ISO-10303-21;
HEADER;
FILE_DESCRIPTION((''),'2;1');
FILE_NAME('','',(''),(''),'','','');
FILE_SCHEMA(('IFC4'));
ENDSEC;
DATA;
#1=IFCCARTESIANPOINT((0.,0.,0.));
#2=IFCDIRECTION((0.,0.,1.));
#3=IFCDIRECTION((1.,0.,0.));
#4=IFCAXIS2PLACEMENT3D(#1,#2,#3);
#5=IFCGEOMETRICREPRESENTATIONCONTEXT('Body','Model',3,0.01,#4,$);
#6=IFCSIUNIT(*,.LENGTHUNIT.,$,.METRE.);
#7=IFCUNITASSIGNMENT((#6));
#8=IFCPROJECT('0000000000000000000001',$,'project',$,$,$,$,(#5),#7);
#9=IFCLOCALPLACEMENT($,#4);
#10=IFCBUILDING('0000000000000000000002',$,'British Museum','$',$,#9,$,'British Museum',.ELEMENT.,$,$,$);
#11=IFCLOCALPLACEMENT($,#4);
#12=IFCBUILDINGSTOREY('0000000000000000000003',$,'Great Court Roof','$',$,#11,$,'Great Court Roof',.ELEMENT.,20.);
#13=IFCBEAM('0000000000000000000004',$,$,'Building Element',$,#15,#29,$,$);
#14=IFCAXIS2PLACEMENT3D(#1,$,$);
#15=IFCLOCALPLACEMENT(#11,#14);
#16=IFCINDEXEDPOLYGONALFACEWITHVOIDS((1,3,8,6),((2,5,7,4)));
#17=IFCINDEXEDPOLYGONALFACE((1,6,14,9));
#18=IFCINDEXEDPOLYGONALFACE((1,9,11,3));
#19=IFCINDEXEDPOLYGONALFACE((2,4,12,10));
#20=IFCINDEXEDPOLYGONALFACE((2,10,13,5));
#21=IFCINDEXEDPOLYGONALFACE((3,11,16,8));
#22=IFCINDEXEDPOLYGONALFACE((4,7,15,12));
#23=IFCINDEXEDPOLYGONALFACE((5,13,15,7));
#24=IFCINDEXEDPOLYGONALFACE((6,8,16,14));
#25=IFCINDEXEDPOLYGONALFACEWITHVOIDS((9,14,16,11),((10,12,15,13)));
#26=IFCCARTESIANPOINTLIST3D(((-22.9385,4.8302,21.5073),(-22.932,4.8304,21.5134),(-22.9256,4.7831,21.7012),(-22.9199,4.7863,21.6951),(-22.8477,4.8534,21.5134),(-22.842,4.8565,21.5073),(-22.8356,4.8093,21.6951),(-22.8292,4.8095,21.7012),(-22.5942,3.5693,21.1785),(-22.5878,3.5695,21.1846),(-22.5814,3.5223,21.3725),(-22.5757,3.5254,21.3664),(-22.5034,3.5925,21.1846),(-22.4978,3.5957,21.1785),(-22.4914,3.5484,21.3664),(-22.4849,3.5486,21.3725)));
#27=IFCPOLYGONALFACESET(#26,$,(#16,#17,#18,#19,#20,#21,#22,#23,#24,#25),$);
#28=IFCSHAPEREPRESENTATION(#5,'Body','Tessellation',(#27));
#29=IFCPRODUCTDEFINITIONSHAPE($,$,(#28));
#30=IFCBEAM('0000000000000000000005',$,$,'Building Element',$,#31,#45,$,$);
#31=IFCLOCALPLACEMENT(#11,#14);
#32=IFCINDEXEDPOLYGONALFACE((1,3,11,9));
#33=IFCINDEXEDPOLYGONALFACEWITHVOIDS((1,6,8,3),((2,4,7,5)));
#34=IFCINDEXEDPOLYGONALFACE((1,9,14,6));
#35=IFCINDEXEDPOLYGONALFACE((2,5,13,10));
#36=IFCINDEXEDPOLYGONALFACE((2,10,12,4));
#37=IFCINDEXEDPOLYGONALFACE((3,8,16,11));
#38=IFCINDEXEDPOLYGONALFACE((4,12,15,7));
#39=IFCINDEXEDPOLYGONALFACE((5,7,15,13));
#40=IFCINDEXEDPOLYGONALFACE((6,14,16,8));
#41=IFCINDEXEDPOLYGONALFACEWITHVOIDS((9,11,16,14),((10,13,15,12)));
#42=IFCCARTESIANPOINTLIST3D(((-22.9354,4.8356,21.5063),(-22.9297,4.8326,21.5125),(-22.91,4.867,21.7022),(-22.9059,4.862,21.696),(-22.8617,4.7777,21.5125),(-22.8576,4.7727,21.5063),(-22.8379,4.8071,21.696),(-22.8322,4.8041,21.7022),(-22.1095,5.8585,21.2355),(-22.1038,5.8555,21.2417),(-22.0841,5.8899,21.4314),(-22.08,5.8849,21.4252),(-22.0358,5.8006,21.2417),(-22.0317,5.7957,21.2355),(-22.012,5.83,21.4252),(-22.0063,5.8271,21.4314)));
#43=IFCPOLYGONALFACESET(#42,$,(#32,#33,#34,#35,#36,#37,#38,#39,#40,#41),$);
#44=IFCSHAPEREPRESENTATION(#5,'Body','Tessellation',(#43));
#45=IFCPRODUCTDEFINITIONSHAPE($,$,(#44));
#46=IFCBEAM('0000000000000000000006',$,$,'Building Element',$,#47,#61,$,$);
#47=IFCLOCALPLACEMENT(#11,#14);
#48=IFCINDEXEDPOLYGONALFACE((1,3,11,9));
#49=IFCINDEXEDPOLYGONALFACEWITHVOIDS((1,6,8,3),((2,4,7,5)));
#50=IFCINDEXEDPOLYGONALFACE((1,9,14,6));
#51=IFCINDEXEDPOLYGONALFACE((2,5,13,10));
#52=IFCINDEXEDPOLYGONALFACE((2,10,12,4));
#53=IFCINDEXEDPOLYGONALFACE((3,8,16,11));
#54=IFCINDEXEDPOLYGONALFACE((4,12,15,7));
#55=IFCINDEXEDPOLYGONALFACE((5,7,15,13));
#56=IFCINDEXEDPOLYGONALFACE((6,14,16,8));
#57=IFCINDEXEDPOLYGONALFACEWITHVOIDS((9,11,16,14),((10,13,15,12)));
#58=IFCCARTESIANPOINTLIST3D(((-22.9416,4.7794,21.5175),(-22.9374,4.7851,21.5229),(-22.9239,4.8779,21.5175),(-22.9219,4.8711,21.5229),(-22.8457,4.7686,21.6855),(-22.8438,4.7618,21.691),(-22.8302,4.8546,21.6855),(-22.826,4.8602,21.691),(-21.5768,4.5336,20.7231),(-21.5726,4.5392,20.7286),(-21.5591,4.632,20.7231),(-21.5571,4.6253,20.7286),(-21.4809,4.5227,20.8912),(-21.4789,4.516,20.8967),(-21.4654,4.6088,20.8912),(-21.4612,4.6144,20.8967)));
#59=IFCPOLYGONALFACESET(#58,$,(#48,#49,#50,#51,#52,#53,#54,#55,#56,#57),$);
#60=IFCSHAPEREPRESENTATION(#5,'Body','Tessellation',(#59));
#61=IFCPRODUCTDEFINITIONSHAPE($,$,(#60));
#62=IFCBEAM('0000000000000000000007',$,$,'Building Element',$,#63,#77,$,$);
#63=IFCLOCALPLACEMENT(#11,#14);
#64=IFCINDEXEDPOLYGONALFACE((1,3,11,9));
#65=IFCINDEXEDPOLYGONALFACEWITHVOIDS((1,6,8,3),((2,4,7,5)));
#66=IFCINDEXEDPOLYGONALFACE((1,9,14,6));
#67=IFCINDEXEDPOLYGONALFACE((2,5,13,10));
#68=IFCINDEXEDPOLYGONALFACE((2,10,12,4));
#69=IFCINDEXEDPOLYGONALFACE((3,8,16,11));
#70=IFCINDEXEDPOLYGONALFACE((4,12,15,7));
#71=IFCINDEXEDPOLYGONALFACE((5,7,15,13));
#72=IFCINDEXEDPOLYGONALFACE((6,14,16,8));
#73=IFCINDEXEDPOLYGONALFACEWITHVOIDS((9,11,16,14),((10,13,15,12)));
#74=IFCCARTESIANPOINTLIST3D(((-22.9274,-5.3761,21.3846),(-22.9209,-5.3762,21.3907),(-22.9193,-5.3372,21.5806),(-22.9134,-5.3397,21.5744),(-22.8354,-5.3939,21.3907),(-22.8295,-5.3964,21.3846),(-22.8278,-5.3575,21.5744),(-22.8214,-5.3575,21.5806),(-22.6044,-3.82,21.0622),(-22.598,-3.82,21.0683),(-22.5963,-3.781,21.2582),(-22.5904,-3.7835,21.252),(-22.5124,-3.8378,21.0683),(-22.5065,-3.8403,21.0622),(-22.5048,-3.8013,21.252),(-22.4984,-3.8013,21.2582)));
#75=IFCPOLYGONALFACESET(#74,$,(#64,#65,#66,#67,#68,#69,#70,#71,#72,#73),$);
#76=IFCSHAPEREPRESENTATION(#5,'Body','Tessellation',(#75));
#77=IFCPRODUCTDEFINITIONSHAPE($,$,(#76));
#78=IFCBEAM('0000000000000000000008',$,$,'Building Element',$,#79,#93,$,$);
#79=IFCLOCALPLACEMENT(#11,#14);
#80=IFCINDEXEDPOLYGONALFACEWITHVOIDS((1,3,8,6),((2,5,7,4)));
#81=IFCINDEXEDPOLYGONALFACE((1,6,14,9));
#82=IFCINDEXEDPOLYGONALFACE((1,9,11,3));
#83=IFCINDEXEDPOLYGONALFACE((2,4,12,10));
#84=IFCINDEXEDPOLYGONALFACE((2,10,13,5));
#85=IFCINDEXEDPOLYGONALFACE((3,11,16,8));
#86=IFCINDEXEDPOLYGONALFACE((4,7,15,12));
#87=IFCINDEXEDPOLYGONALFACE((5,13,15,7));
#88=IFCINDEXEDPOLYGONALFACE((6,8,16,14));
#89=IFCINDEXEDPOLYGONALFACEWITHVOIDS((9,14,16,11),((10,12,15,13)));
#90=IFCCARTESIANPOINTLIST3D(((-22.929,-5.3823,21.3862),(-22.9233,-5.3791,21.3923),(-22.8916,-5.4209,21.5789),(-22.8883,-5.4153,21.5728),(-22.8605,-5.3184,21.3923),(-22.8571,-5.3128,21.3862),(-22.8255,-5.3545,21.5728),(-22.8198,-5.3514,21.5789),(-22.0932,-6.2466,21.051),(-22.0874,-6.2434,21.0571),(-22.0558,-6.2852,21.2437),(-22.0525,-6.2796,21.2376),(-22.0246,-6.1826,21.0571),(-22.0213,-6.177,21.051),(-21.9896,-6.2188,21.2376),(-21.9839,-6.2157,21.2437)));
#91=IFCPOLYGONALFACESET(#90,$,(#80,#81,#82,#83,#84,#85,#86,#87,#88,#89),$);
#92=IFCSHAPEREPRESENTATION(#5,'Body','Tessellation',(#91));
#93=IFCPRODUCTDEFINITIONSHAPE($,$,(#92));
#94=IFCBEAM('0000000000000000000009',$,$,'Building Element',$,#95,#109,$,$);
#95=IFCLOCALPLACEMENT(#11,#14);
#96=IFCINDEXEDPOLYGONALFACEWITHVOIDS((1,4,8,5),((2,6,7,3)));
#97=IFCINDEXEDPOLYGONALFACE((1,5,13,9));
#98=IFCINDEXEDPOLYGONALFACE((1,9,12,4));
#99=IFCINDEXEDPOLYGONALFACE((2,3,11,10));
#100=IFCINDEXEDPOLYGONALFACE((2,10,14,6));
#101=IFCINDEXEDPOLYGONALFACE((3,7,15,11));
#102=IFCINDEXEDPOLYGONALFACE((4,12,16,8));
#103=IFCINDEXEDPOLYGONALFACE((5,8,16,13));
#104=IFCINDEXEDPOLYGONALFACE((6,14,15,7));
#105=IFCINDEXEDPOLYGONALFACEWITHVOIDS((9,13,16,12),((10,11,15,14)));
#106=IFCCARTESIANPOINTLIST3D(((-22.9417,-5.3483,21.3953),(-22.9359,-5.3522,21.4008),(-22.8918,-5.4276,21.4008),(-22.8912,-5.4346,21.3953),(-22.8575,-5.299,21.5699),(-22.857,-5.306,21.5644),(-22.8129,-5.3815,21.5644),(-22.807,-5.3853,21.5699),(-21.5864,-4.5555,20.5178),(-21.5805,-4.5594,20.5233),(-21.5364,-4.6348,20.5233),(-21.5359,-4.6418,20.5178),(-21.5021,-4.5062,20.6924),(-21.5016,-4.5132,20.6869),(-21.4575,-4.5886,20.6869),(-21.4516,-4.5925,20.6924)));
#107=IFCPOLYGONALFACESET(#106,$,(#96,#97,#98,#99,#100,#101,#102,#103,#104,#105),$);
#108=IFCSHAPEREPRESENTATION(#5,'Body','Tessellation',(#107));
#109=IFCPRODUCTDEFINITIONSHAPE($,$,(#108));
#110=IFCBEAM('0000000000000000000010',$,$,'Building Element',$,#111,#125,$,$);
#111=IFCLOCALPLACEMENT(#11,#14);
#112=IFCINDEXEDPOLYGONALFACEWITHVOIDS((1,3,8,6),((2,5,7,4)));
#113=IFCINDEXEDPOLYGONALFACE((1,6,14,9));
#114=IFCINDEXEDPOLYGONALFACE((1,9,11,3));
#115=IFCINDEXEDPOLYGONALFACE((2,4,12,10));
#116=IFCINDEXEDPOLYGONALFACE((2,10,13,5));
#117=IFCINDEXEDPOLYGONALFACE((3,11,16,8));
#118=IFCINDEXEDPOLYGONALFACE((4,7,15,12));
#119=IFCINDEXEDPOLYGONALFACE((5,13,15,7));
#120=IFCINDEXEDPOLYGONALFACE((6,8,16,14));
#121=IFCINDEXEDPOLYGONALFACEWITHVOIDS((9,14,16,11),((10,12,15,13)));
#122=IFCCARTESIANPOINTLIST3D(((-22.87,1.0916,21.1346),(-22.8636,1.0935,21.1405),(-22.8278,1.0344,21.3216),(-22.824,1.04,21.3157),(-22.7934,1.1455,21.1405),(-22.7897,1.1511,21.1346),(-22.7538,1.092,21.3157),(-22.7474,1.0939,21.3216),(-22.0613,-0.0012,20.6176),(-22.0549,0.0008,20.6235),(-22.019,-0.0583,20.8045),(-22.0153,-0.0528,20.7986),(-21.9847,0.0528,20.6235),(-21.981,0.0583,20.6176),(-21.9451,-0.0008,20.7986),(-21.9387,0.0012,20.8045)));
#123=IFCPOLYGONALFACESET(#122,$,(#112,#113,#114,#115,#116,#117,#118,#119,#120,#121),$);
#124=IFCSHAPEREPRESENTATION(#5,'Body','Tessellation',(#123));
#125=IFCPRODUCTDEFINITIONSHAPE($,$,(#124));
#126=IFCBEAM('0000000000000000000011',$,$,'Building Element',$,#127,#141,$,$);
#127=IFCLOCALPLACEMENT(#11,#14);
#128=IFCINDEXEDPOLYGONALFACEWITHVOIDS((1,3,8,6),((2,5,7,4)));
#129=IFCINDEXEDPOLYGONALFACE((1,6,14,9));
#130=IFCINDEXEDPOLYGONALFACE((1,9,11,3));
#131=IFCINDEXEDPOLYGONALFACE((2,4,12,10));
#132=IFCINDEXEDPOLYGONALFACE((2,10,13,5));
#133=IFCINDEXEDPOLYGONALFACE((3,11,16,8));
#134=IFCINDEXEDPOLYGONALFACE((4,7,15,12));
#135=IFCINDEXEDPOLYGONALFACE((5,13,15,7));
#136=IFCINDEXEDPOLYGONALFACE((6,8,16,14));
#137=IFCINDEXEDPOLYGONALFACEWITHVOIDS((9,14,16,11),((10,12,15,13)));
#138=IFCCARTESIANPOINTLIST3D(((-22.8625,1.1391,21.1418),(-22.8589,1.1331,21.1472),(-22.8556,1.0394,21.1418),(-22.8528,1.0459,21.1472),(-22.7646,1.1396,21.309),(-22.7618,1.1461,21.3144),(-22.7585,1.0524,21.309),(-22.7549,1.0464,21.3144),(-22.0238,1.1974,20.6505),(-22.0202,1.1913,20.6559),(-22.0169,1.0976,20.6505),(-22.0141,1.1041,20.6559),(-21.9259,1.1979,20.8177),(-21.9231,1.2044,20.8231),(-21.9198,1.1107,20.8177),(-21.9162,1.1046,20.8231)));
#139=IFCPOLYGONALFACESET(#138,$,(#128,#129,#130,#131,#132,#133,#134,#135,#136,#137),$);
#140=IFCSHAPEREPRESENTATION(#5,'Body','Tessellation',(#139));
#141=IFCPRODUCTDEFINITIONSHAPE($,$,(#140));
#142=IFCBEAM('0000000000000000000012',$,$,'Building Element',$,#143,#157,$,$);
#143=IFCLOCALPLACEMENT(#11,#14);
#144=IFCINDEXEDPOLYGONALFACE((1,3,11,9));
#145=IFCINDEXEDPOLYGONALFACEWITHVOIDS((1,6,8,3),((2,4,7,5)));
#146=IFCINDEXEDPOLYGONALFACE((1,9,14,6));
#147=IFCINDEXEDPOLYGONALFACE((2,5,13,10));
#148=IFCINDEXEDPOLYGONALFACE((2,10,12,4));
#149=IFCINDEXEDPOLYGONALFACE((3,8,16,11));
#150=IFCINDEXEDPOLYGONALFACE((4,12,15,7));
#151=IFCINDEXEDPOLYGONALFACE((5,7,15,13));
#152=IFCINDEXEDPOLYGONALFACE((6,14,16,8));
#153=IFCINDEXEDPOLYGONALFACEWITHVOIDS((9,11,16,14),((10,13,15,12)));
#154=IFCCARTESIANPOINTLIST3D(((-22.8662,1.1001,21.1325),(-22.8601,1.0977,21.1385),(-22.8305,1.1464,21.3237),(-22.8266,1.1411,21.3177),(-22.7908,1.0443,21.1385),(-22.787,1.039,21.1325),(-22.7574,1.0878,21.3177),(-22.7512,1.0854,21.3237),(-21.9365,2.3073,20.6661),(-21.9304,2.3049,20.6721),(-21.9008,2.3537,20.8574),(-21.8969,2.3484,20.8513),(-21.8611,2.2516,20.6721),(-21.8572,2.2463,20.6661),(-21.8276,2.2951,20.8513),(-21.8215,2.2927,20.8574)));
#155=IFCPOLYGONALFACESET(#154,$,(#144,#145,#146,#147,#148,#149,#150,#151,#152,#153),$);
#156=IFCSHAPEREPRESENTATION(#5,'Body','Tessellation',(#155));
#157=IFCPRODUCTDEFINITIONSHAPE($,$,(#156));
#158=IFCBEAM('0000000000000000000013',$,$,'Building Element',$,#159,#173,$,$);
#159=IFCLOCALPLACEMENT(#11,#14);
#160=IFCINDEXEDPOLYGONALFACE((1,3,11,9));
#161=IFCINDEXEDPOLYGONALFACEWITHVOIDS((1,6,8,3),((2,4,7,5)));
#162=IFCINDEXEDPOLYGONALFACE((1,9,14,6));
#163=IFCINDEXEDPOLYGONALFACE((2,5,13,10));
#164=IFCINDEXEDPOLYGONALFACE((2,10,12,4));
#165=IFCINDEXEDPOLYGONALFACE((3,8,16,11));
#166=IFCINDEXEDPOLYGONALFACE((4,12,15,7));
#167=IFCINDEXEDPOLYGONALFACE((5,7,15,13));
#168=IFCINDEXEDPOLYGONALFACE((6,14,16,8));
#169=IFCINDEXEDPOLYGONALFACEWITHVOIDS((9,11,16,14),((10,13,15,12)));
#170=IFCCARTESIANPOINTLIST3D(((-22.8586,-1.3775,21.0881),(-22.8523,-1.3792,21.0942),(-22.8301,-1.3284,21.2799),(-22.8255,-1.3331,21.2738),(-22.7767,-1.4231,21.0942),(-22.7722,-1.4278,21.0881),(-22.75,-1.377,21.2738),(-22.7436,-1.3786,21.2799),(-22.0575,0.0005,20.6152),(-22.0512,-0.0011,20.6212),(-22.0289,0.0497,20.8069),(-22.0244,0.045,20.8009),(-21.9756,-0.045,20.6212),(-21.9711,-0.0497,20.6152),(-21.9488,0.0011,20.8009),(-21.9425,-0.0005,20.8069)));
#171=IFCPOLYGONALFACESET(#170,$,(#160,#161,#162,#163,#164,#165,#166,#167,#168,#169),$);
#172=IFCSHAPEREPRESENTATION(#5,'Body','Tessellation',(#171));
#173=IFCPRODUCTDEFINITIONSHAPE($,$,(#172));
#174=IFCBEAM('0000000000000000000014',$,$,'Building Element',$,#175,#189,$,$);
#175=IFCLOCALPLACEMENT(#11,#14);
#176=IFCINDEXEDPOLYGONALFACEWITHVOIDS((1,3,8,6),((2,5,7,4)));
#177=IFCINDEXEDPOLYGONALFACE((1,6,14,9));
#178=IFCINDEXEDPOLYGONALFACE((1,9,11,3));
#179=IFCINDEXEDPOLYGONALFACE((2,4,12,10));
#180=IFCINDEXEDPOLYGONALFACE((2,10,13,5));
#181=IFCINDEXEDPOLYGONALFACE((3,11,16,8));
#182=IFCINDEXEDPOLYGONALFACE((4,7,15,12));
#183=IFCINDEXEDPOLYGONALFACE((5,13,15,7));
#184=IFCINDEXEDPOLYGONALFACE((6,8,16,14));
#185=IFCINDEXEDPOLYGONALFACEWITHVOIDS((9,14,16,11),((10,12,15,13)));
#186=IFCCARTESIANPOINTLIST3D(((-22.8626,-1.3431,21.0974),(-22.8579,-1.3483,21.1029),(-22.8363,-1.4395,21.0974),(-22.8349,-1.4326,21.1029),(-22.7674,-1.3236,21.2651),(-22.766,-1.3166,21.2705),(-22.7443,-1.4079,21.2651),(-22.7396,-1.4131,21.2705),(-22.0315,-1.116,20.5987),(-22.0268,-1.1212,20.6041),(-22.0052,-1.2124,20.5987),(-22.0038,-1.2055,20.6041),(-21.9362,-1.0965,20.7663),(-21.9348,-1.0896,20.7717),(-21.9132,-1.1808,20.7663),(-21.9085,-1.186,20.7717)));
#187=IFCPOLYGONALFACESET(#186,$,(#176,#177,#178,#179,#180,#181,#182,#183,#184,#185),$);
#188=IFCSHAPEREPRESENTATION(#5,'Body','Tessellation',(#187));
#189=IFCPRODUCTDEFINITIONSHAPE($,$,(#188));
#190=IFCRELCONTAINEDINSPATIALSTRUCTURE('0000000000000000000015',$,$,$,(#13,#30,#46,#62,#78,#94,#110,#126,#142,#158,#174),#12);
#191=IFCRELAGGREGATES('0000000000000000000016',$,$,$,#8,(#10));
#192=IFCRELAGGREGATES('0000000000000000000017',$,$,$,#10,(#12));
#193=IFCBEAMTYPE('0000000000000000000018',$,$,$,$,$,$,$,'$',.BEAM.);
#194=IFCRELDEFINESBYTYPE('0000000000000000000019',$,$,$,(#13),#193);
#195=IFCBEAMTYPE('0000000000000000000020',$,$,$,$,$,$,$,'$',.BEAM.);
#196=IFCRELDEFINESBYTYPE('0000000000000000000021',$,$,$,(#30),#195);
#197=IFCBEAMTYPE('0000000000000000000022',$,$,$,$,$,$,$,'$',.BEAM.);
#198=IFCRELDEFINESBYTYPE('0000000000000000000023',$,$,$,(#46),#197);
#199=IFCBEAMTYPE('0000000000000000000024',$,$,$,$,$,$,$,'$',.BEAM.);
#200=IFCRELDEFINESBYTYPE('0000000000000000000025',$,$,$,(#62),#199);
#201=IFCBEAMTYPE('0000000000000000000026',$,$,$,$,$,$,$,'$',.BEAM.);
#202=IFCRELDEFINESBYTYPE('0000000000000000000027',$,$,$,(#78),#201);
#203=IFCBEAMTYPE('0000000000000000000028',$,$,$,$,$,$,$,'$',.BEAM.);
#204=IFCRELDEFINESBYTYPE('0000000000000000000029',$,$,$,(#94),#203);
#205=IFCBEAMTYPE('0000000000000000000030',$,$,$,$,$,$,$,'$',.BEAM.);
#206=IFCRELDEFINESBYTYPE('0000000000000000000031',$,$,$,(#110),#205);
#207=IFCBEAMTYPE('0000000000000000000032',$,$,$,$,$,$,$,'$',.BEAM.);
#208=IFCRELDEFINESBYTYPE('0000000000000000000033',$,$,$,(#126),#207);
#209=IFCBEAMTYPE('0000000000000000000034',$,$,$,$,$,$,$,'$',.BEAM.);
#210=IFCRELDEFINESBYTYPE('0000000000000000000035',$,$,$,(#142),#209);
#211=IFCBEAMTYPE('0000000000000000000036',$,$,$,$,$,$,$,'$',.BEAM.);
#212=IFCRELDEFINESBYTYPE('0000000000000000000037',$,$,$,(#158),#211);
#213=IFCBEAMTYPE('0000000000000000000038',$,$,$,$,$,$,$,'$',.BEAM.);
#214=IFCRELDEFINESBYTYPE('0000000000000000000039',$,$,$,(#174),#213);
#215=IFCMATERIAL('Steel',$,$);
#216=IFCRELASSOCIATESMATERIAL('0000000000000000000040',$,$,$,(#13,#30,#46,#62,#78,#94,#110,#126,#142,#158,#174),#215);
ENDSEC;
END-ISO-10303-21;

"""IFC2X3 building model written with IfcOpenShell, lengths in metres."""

from ifc_helpers import new_model, si_unit, frame, origin_with_axes, origin_2d, place, context, project, spatial, hollow_rectangle, extrude, material, type_object, element, save


model = new_model("IFC2X3")

# Units and contexts
model_context = context("Model", 3, precision=0.01, world=origin_with_axes(), identifier="Body")
ifc_project = project(units=[si_unit("LENGTHUNIT", "METRE")], contexts=[model_context])

# Building, storey
building_placement = place(None, origin_with_axes())
building = spatial("IfcBuilding", under=ifc_project, at=building_placement, Name="British Museum", Description="$", LongName="British Museum", CompositionType="ELEMENT")
storey_placement = place(None, origin_with_axes())
storey = spatial("IfcBuildingStorey", under=building, at=storey_placement, Name="Great Court Roof", Description="$", LongName="Great Court Roof", CompositionType="ELEMENT", Elevation=20.0)

# Beams
ifc_material = material(Name="Steel")
beam_type_1 = type_object("IfcBeamType", ElementType="$", PredefinedType="BEAM")
beam_1_placement = place(None, origin_with_axes())
element("IfcBeam", 1, at=beam_1_placement, inside=storey, type_object=beam_type_1, material=ifc_material, Description="Building Element", context=model_context, shape_type="SweptSolid", body=[
    extrude(hollow_rectangle(XDim=0.1, YDim=0.2, WallThickness=0.0063, InnerFilletRadius=-0.0063, OuterFilletRadius=0.0, at=origin_2d()), frame((-22.8838, 4.8198, 21.6042), z_axis=(0.255412, -0.935555, -0.243927), x_axis=(0.964695, 0.263368, 0.0)), (0.0, 0.0, 1.0), 1.3477),
])
beam_type_2 = type_object("IfcBeamType", ElementType="$", PredefinedType="BEAM")
beam_2_placement = place(None, origin_with_axes())
element("IfcBeam", 2, at=beam_2_placement, inside=storey, type_object=beam_type_2, material=ifc_material, Description="Building Element", context=model_context, shape_type="SweptSolid", body=[
    extrude(hollow_rectangle(XDim=0.1, YDim=0.2, WallThickness=0.0063, InnerFilletRadius=-0.0063, OuterFilletRadius=0.0, at=origin_2d()), frame((-22.8838, 4.8198, 21.6042), z_axis=(0.615277, 0.762063, -0.201726), x_axis=(-0.778059, 0.628192, 0.0)), (0.0, 0.0, 1.0), 1.3423),
])
beam_type_3 = type_object("IfcBeamType", ElementType="$", PredefinedType="BEAM")
beam_3_placement = place(None, origin_with_axes())
element("IfcBeam", 3, at=beam_3_placement, inside=storey, type_object=beam_type_3, material=ifc_material, Description="Building Element", context=model_context, shape_type="SweptSolid", body=[
    extrude(hollow_rectangle(XDim=0.1, YDim=0.2, WallThickness=0.0063, InnerFilletRadius=-0.0063, OuterFilletRadius=0.0, at=origin_2d()), frame((-22.8838, 4.8198, 21.6042), z_axis=(0.853982, -0.153829, -0.497043), x_axis=(0.177278, 0.984161, 0.0)), (0.0, 0.0, 1.0), 1.5982),
])
beam_type_4 = type_object("IfcBeamType", ElementType="$", PredefinedType="BEAM")
beam_4_placement = place(None, origin_with_axes())
element("IfcBeam", 4, at=beam_4_placement, inside=storey, type_object=beam_type_4, material=ifc_material, Description="Building Element", context=model_context, shape_type="SweptSolid", body=[
    extrude(hollow_rectangle(XDim=0.1, YDim=0.2, WallThickness=0.0063, InnerFilletRadius=-0.0063, OuterFilletRadius=0.0, at=origin_2d()), frame((-22.8744, -5.3668, 21.4826), z_axis=(0.199166, 0.959588, -0.198807), x_axis=(-0.979133, 0.203222, 0.0)), (0.0, 0.0, 1.0), 1.6217),
])
beam_type_5 = type_object("IfcBeamType", ElementType="$", PredefinedType="BEAM")
beam_5_placement = place(None, origin_with_axes())
element("IfcBeam", 5, at=beam_5_placement, inside=storey, type_object=beam_type_5, material=ifc_material, Description="Building Element", context=model_context, shape_type="SweptSolid", body=[
    extrude(hollow_rectangle(XDim=0.1, YDim=0.2, WallThickness=0.0063, InnerFilletRadius=-0.0063, OuterFilletRadius=0.0, at=origin_2d()), frame((-22.8744, -5.3668, 21.4826), z_axis=(0.669635, -0.692431, -0.268568), x_axis=(0.71884, 0.695175, 0.0)), (0.0, 0.0, 1.0), 1.2482),
])
beam_type_6 = type_object("IfcBeamType", ElementType="$", PredefinedType="BEAM")
beam_6_placement = place(None, origin_with_axes())
element("IfcBeam", 6, at=beam_6_placement, inside=storey, type_object=beam_type_6, material=ifc_material, Description="Building Element", context=model_context, shape_type="SweptSolid", body=[
    extrude(hollow_rectangle(XDim=0.1, YDim=0.2, WallThickness=0.0063, InnerFilletRadius=-0.0063, OuterFilletRadius=0.0, at=origin_2d()), frame((-22.8744, -5.3668, 21.4826), z_axis=(0.753497, 0.440756, -0.487828), x_axis=(-0.50491, 0.863172, 0.0)), (0.0, 0.0, 1.0), 1.7988),
])
beam_type_7 = type_object("IfcBeamType", ElementType="$", PredefinedType="BEAM")
beam_7_placement = place(None, origin_with_axes())
element("IfcBeam", 7, at=beam_7_placement, inside=storey, type_object=beam_type_7, material=ifc_material, Description="Building Element", context=model_context, shape_type="SweptSolid", body=[
    extrude(hollow_rectangle(XDim=0.1, YDim=0.2, WallThickness=0.0063, InnerFilletRadius=-0.0063, OuterFilletRadius=0.0, at=origin_2d()), frame((-22.8087, 1.0927, 21.2281), z_axis=(0.556025, -0.751309, -0.355487), x_axis=(0.803813, 0.594882, 0.0)), (0.0, 0.0, 1.0), 1.4544),
])
beam_type_8 = type_object("IfcBeamType", ElementType="$", PredefinedType="BEAM")
beam_8_placement = place(None, origin_with_axes())
element("IfcBeam", 8, at=beam_8_placement, inside=storey, type_object=beam_type_8, material=ifc_material, Description="Building Element", context=model_context, shape_type="SweptSolid", body=[
    extrude(hollow_rectangle(XDim=0.1, YDim=0.2, WallThickness=0.0063, InnerFilletRadius=-0.0063, OuterFilletRadius=0.0, at=origin_2d()), frame((-22.8087, 1.0927, 21.2281), z_axis=(0.861308, 0.059832, -0.504547), x_axis=(-0.069299, 0.997596, 0.0)), (0.0, 0.0, 1.0), 0.9738),
])
beam_type_9 = type_object("IfcBeamType", ElementType="$", PredefinedType="BEAM")
beam_9_placement = place(None, origin_with_axes())
element("IfcBeam", 9, at=beam_9_placement, inside=storey, type_object=beam_type_9, material=ifc_material, Description="Building Element", context=model_context, shape_type="SweptSolid", body=[
    extrude(hollow_rectangle(XDim=0.1, YDim=0.2, WallThickness=0.0063, InnerFilletRadius=-0.0063, OuterFilletRadius=0.0, at=origin_2d()), frame((-22.8087, 1.0927, 21.2281), z_axis=(0.583427, 0.757602, -0.292665), x_axis=(-0.792292, 0.610141, 0.0)), (0.0, 0.0, 1.0), 1.5935),
])
beam_type_10 = type_object("IfcBeamType", ElementType="$", PredefinedType="BEAM")
beam_10_placement = place(None, origin_with_axes())
element("IfcBeam", 10, at=beam_10_placement, inside=storey, type_object=beam_type_10, material=ifc_material, Description="Building Element", context=model_context, shape_type="SweptSolid", body=[
    extrude(hollow_rectangle(XDim=0.1, YDim=0.2, WallThickness=0.0063, InnerFilletRadius=-0.0063, OuterFilletRadius=0.0, at=origin_2d()), frame((-22.8011, -1.3781, 21.184), z_axis=(0.481822, 0.828824, -0.284425), x_axis=(-0.864531, 0.502579, 0.0)), (0.0, 0.0, 1.0), 1.6627),
])
beam_type_11 = type_object("IfcBeamType", ElementType="$", PredefinedType="BEAM")
beam_11_placement = place(None, origin_with_axes())
element("IfcBeam", 11, at=beam_11_placement, inside=storey, type_object=beam_type_11, material=ifc_material, Description="Building Element", context=model_context, shape_type="SweptSolid", body=[
    extrude(hollow_rectangle(XDim=0.1, YDim=0.2, WallThickness=0.0063, InnerFilletRadius=-0.0063, OuterFilletRadius=0.0, at=origin_2d()), frame((-22.8011, -1.3781, 21.184), z_axis=(0.834841, 0.228101, -0.501009), x_axis=(-0.263566, 0.964641, 0.0)), (0.0, 0.0, 1.0), 0.9955),
])

save(model, "model.ifc")
